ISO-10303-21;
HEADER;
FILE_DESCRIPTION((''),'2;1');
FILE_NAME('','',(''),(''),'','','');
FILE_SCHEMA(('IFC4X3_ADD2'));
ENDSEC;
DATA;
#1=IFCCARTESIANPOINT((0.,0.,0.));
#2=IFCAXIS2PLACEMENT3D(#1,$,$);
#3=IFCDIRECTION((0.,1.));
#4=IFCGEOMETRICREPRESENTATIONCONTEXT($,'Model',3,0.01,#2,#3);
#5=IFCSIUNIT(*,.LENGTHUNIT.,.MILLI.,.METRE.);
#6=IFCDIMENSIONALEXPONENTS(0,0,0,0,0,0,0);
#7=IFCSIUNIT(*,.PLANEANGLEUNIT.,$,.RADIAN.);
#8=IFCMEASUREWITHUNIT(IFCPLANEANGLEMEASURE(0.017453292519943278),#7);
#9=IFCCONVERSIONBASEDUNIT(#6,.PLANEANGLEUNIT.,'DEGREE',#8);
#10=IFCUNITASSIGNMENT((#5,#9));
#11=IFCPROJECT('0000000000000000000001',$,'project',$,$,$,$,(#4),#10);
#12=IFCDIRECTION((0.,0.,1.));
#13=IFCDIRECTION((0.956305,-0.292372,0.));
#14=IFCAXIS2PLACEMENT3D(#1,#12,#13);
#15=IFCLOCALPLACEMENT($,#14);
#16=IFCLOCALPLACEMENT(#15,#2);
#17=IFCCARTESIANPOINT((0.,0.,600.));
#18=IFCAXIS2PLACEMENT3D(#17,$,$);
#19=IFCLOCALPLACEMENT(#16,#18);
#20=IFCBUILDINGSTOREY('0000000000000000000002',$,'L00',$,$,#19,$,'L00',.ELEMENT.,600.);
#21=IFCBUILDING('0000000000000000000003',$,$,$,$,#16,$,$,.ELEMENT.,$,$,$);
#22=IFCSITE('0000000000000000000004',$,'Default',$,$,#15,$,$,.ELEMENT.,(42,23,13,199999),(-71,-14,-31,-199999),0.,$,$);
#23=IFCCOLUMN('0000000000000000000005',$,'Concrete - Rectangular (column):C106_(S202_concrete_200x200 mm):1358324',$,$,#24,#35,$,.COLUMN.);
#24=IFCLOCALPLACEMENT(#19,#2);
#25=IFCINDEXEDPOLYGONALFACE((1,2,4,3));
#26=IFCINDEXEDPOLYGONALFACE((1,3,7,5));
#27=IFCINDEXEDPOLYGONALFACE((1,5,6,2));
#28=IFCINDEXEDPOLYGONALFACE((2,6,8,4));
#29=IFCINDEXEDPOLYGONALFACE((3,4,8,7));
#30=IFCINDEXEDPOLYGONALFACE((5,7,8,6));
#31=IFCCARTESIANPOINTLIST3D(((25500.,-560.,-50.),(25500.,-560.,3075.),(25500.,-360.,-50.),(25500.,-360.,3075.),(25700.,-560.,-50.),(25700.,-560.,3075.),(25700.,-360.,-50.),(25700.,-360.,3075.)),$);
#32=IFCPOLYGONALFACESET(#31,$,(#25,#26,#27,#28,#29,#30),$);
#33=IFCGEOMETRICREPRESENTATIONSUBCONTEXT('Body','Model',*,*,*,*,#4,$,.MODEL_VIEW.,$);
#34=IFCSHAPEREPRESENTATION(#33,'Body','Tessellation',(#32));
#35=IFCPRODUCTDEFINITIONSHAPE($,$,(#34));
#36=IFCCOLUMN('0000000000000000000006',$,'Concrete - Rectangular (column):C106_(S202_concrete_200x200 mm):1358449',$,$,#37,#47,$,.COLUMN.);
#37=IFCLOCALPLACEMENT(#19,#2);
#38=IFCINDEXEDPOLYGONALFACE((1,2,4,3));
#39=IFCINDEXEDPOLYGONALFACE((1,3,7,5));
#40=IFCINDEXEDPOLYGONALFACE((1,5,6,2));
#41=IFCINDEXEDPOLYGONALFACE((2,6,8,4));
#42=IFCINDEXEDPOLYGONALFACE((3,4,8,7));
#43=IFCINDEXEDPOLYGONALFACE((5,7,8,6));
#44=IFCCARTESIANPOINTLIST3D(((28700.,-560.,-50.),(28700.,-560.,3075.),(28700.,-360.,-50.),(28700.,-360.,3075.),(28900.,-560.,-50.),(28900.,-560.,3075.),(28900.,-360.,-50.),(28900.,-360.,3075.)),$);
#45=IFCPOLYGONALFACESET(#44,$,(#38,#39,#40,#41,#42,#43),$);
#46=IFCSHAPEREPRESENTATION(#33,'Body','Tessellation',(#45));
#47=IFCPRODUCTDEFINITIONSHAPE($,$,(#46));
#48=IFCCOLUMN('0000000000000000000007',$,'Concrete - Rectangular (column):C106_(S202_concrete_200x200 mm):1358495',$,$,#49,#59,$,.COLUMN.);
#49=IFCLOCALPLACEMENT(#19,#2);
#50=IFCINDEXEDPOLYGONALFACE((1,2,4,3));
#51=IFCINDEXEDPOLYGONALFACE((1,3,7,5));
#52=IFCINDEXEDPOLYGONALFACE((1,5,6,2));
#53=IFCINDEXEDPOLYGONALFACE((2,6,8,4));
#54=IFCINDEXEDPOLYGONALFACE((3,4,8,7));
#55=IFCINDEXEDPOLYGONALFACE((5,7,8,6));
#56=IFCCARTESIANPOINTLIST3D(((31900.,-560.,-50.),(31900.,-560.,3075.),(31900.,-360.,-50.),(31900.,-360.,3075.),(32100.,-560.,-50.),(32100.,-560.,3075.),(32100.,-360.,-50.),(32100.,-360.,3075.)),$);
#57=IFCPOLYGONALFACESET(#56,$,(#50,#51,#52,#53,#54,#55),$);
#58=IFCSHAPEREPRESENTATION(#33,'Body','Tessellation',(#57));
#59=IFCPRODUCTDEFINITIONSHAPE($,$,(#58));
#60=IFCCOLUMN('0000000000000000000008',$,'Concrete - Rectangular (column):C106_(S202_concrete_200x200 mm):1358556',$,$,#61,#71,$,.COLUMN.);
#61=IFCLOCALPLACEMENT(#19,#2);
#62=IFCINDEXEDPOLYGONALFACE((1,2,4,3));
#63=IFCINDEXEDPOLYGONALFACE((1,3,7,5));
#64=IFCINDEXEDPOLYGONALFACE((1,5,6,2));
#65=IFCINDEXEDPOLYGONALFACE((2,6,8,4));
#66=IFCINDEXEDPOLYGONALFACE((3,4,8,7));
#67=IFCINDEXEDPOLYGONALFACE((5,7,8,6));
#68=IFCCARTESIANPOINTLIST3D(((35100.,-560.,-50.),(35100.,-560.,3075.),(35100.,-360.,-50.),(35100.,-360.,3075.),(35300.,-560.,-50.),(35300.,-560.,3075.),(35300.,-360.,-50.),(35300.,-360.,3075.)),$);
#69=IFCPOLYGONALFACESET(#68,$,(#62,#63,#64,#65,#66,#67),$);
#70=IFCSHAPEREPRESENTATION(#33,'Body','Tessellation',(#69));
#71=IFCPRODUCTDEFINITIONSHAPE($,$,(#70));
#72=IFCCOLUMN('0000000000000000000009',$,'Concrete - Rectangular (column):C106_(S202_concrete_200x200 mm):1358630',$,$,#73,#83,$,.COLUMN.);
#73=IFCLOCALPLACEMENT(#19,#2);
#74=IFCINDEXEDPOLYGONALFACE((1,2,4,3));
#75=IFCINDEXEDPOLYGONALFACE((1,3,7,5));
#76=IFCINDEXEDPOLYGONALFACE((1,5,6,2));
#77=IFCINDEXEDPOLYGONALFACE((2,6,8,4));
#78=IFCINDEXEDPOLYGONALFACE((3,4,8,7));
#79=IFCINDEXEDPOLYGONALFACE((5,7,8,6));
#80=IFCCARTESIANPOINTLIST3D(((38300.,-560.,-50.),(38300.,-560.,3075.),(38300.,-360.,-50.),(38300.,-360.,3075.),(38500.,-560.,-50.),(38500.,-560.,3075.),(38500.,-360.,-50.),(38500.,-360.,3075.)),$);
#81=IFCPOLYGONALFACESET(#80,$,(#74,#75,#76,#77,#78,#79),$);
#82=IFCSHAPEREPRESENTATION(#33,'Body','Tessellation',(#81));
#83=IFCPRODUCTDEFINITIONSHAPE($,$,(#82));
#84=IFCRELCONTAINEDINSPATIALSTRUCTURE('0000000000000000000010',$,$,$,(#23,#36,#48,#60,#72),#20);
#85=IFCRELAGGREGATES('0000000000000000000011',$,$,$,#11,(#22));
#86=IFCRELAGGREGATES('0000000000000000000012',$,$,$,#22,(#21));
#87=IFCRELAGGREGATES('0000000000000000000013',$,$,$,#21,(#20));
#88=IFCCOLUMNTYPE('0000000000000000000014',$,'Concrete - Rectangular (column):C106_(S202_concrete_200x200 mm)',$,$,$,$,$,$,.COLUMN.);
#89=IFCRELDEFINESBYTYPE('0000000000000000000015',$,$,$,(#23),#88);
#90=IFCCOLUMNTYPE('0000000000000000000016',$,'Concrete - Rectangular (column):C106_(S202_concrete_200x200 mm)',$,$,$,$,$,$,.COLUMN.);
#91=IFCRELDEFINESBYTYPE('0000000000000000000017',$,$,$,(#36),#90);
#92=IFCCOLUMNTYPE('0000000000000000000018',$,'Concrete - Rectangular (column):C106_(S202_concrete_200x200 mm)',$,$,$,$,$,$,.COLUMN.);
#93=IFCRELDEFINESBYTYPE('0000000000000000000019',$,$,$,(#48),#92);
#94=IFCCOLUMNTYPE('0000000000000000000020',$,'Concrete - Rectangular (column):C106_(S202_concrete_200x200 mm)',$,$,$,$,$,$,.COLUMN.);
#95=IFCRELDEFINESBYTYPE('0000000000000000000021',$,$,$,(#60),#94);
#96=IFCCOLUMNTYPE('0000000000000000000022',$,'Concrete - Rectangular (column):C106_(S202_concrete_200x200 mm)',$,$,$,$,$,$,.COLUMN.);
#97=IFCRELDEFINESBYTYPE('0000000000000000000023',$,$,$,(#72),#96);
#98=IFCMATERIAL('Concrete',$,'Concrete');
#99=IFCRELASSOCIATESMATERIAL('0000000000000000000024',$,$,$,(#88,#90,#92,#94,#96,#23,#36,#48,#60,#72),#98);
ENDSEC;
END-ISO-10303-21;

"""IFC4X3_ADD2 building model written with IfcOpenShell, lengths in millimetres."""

from ifc_helpers import new_model, entity, si_unit, converted_unit, direction, frame, frame_2d, origin, place, context, subcontext, project, spatial, rectangle, extrude, source, transform, mapped, material, material_profile, profile_set, profile_usage, type_object, type_shapes, element, save


model = new_model("IFC4X3_ADD2")

# Units and contexts
model_context = context("Model", 3, precision=0.01, world=origin(), true_north=direction((0.0, 1.0)))
body_context = subcontext(model_context, "Body", "Model", "MODEL_VIEW")
ifc_project = project(units=[si_unit("LENGTHUNIT", "METRE", prefix="MILLI"), converted_unit("PLANEANGLEUNIT", "DEGREE", entity("IfcPlaneAngleMeasure", 0.017453292519943278), si_unit("PLANEANGLEUNIT", "RADIAN"), dimensions=[0, 0, 0, 0, 0, 0, 0])], contexts=[model_context])

# Site, building, storey
site_placement = place(None, frame((0.0, 0.0, 0.0), z_axis=(0.0, 0.0, 1.0), x_axis=(0.956305, -0.292372, 0.0)))
site = spatial("IfcSite", under=ifc_project, at=site_placement, Name="Default", CompositionType="ELEMENT", RefLatitude=(42, 23, 13, 199999), RefLongitude=(-71, -14, -31, -199999), RefElevation=0.0)
building_placement = place(site_placement, origin())
building = spatial("IfcBuilding", under=site, at=building_placement, CompositionType="ELEMENT")
storey_placement = place(building_placement, frame((0.0, 0.0, 600.0)))
storey = spatial("IfcBuildingStorey", under=building, at=storey_placement, Name="L00", LongName="L00", CompositionType="ELEMENT", Elevation=600.0)

# Columns
ifc_material_1 = material(Name="Concrete", Category="Concrete")
ifc_material_profile_1 = material_profile(ifc_material_1, rectangle(XDim=200.0, YDim=200.0, at=frame_2d((0.0, 0.0), x_axis=(1.0, 0.0))), Name="C106_(S202_concrete_200x200 mm)")
ifc_profile_set_1 = profile_set([ifc_material_profile_1], Name="C106_(S202_concrete_200x200 mm)")
ifc_profile_usage_1 = profile_usage(ifc_profile_set_1)
column_type_1 = type_object("IfcColumnType", Name="Concrete - Rectangular (column):C106_(S202_concrete_200x200 mm)", PredefinedType="COLUMN", material=ifc_profile_set_1)
shared_shape_1 = source(origin(), body_context, "Body", "SweptSolid", [
    extrude(rectangle(XDim=200.0, YDim=200.0, at=frame_2d((0.0, 0.0), x_axis=(1.0, 0.0))), frame((25600.0, -460.0, 550.0), z_axis=(0.0, 0.0, 1.0), x_axis=(0.0, 1.0, 0.0)), (0.0, 0.0, 1.0), 3125.0),
])
type_shapes(column_type_1, [shared_shape_1])
column_1_placement = place(storey_placement, frame((0.0, 0.0, -600.0)))
element("IfcColumn", 1, at=column_1_placement, inside=storey, type_object=column_type_1, material=ifc_profile_usage_1, Name="Concrete - Rectangular (column):C106_(S202_concrete_200x200 mm):1358324", PredefinedType="COLUMN", context=body_context, shape_type="MappedRepresentation", body=[
    mapped(shared_shape_1, transform((0.0, 0.0, 0.0), scale=1.0)),
])
column_type_2 = type_object("IfcColumnType", Name="Concrete - Rectangular (column):C106_(S202_concrete_200x200 mm)", PredefinedType="COLUMN", material=ifc_profile_set_1)
shared_shape_2 = source(origin(), body_context, "Body", "SweptSolid", [
    extrude(rectangle(XDim=200.0, YDim=200.0, at=frame_2d((0.0, 0.0), x_axis=(1.0, 0.0))), frame((28800.0, -460.0, 550.0), z_axis=(0.0, 0.0, 1.0), x_axis=(0.0, 1.0, 0.0)), (0.0, 0.0, 1.0), 3125.0),
])
type_shapes(column_type_2, [shared_shape_2])
column_2_placement = place(storey_placement, frame((0.0, 0.0, -600.0)))
element("IfcColumn", 2, at=column_2_placement, inside=storey, type_object=column_type_2, material=ifc_profile_usage_1, Name="Concrete - Rectangular (column):C106_(S202_concrete_200x200 mm):1358449", PredefinedType="COLUMN", context=body_context, shape_type="MappedRepresentation", body=[
    mapped(shared_shape_2, transform((0.0, 0.0, 0.0), scale=1.0)),
])
column_type_3 = type_object("IfcColumnType", Name="Concrete - Rectangular (column):C106_(S202_concrete_200x200 mm)", PredefinedType="COLUMN", material=ifc_profile_set_1)
shared_shape_3 = source(origin(), body_context, "Body", "SweptSolid", [
    extrude(rectangle(XDim=200.0, YDim=200.0, at=frame_2d((0.0, 0.0), x_axis=(1.0, 0.0))), frame((32000.0, -460.0, 550.0), z_axis=(0.0, 0.0, 1.0), x_axis=(0.0, 1.0, 0.0)), (0.0, 0.0, 1.0), 3125.0),
])
type_shapes(column_type_3, [shared_shape_3])
column_3_placement = place(storey_placement, frame((0.0, 0.0, -600.0)))
element("IfcColumn", 3, at=column_3_placement, inside=storey, type_object=column_type_3, material=ifc_profile_usage_1, Name="Concrete - Rectangular (column):C106_(S202_concrete_200x200 mm):1358495", PredefinedType="COLUMN", context=body_context, shape_type="MappedRepresentation", body=[
    mapped(shared_shape_3, transform((0.0, 0.0, 0.0), scale=1.0)),
])
column_type_4 = type_object("IfcColumnType", Name="Concrete - Rectangular (column):C106_(S202_concrete_200x200 mm)", PredefinedType="COLUMN", material=ifc_profile_set_1)
shared_shape_4 = source(origin(), body_context, "Body", "SweptSolid", [
    extrude(rectangle(XDim=200.0, YDim=200.0, at=frame_2d((0.0, 0.0), x_axis=(1.0, 0.0))), frame((35200.0, -460.0, 550.0), z_axis=(0.0, 0.0, 1.0), x_axis=(0.0, 1.0, 0.0)), (0.0, 0.0, 1.0), 3125.0),
])
type_shapes(column_type_4, [shared_shape_4])
column_4_placement = place(storey_placement, frame((0.0, 0.0, -600.0)))
element("IfcColumn", 4, at=column_4_placement, inside=storey, type_object=column_type_4, material=ifc_profile_usage_1, Name="Concrete - Rectangular (column):C106_(S202_concrete_200x200 mm):1358556", PredefinedType="COLUMN", context=body_context, shape_type="MappedRepresentation", body=[
    mapped(shared_shape_4, transform((0.0, 0.0, 0.0), scale=1.0)),
])
column_type_5 = type_object("IfcColumnType", Name="Concrete - Rectangular (column):C106_(S202_concrete_200x200 mm)", PredefinedType="COLUMN", material=ifc_profile_set_1)
shared_shape_5 = source(origin(), body_context, "Body", "SweptSolid", [
    extrude(rectangle(XDim=200.0, YDim=200.0, at=frame_2d((0.0, 0.0), x_axis=(1.0, 0.0))), frame((38400.0, -460.0, 550.0), z_axis=(0.0, 0.0, 1.0), x_axis=(0.0, 1.0, 0.0)), (0.0, 0.0, 1.0), 3125.0),
])
type_shapes(column_type_5, [shared_shape_5])
column_5_placement = place(storey_placement, frame((0.0, 0.0, -600.0)))
element("IfcColumn", 5, at=column_5_placement, inside=storey, type_object=column_type_5, material=ifc_profile_usage_1, Name="Concrete - Rectangular (column):C106_(S202_concrete_200x200 mm):1358630", PredefinedType="COLUMN", context=body_context, shape_type="MappedRepresentation", body=[
    mapped(shared_shape_5, transform((0.0, 0.0, 0.0), scale=1.0)),
])

save(model, "model.ifc")
